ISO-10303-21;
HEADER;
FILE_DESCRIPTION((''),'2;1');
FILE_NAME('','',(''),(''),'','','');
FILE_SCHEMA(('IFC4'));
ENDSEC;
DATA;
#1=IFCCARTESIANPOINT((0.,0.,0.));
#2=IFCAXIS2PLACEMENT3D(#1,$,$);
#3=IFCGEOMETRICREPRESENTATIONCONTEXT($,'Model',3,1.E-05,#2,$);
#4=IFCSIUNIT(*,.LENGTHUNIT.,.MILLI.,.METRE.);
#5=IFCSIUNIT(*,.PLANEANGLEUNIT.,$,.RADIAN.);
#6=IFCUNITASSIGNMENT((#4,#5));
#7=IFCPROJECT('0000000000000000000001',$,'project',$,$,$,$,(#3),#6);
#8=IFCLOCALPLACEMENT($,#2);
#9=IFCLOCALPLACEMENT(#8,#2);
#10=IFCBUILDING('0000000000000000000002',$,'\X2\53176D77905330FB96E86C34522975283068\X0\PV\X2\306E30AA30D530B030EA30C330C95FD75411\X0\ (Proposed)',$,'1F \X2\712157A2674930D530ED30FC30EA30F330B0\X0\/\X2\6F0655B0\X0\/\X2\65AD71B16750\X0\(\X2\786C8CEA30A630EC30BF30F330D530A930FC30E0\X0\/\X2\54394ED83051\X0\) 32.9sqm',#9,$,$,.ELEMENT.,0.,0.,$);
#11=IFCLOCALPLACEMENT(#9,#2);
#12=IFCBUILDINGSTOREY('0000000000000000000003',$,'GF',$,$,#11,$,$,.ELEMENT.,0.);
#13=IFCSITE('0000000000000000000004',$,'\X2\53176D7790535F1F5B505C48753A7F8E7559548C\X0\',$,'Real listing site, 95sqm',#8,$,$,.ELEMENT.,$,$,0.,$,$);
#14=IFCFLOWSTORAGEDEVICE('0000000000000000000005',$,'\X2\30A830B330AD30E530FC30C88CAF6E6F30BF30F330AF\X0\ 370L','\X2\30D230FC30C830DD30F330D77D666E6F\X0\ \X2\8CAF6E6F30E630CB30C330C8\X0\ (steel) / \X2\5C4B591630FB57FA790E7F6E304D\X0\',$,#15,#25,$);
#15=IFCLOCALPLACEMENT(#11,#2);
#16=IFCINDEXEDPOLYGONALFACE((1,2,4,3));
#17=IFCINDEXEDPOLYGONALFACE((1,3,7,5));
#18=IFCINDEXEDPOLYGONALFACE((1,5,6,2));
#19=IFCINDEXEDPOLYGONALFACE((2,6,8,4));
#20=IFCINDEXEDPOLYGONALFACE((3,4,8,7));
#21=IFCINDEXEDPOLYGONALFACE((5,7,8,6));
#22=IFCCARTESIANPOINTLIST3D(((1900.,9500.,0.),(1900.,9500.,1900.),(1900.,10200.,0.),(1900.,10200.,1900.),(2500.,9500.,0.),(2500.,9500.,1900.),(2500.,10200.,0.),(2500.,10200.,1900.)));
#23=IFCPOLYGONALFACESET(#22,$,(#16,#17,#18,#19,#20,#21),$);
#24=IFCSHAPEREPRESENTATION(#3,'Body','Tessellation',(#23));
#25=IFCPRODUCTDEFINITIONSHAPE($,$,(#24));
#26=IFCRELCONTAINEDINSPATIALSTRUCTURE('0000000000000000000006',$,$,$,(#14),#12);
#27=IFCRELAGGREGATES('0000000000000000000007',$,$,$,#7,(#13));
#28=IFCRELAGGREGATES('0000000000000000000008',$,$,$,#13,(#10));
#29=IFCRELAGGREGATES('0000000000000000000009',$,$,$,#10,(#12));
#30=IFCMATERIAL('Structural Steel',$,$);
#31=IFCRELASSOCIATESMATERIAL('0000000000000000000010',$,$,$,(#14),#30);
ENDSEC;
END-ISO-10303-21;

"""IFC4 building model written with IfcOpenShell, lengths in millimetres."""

from ifc_helpers import new_model, si_unit, frame, frame_2d, origin, place, context, project, spatial, rectangle, extrude, material, element, save


model = new_model("IFC4")

# Units and contexts
model_context = context("Model", 3, precision=1e-05, world=origin())
ifc_project = project(units=[si_unit("LENGTHUNIT", "METRE", prefix="MILLI"), si_unit("PLANEANGLEUNIT", "RADIAN")], contexts=[model_context])

# Site, building, storey
site_placement = place(None, origin())
site = spatial("IfcSite", under=ifc_project, at=site_placement, Name="北海道弟子屈町美留和", ObjectType="Real listing site, 95sqm", CompositionType="ELEMENT", RefElevation=0.0)
building_placement = place(site_placement, origin())
building = spatial("IfcBuilding", under=site, at=building_placement, Name="北海道・雨水利用とPVのオフグリッド志向 (Proposed)", ObjectType="1F 無垢杉フローリング/漆喰/断熱材(硬質ウレタンフォーム/吹付け) 32.9sqm", CompositionType="ELEMENT", ElevationOfRefHeight=0.0, ElevationOfTerrain=0.0)
storey_placement = place(building_placement, origin())
storey = spatial("IfcBuildingStorey", under=building, at=storey_placement, Name="GF", CompositionType="ELEMENT", Elevation=0.0)

# Shared definitions
ifc_material_1 = material(Name="Structural Steel")

# Flow storage device
flow_storage_device_placement = place(storey_placement, frame((950.0, 4750.0, 0.0)))
element("IfcFlowStorageDevice", 1, at=flow_storage_device_placement, inside=storey, material=ifc_material_1, Name="エコキュート貯湯タンク 370L", Description="ヒートポンプ給湯 貯湯ユニット (steel) / 屋外・基礎置き", context=model_context, shape_type="SweptSolid", body=[
    extrude(rectangle(XDim=600.0, YDim=700.0, at=frame_2d((300.0, 350.0))), frame((950.0, 4750.0, 0.0)), (0.0, 0.0, 1.0), 1900.0),
])

save(model, "model.ifc")
